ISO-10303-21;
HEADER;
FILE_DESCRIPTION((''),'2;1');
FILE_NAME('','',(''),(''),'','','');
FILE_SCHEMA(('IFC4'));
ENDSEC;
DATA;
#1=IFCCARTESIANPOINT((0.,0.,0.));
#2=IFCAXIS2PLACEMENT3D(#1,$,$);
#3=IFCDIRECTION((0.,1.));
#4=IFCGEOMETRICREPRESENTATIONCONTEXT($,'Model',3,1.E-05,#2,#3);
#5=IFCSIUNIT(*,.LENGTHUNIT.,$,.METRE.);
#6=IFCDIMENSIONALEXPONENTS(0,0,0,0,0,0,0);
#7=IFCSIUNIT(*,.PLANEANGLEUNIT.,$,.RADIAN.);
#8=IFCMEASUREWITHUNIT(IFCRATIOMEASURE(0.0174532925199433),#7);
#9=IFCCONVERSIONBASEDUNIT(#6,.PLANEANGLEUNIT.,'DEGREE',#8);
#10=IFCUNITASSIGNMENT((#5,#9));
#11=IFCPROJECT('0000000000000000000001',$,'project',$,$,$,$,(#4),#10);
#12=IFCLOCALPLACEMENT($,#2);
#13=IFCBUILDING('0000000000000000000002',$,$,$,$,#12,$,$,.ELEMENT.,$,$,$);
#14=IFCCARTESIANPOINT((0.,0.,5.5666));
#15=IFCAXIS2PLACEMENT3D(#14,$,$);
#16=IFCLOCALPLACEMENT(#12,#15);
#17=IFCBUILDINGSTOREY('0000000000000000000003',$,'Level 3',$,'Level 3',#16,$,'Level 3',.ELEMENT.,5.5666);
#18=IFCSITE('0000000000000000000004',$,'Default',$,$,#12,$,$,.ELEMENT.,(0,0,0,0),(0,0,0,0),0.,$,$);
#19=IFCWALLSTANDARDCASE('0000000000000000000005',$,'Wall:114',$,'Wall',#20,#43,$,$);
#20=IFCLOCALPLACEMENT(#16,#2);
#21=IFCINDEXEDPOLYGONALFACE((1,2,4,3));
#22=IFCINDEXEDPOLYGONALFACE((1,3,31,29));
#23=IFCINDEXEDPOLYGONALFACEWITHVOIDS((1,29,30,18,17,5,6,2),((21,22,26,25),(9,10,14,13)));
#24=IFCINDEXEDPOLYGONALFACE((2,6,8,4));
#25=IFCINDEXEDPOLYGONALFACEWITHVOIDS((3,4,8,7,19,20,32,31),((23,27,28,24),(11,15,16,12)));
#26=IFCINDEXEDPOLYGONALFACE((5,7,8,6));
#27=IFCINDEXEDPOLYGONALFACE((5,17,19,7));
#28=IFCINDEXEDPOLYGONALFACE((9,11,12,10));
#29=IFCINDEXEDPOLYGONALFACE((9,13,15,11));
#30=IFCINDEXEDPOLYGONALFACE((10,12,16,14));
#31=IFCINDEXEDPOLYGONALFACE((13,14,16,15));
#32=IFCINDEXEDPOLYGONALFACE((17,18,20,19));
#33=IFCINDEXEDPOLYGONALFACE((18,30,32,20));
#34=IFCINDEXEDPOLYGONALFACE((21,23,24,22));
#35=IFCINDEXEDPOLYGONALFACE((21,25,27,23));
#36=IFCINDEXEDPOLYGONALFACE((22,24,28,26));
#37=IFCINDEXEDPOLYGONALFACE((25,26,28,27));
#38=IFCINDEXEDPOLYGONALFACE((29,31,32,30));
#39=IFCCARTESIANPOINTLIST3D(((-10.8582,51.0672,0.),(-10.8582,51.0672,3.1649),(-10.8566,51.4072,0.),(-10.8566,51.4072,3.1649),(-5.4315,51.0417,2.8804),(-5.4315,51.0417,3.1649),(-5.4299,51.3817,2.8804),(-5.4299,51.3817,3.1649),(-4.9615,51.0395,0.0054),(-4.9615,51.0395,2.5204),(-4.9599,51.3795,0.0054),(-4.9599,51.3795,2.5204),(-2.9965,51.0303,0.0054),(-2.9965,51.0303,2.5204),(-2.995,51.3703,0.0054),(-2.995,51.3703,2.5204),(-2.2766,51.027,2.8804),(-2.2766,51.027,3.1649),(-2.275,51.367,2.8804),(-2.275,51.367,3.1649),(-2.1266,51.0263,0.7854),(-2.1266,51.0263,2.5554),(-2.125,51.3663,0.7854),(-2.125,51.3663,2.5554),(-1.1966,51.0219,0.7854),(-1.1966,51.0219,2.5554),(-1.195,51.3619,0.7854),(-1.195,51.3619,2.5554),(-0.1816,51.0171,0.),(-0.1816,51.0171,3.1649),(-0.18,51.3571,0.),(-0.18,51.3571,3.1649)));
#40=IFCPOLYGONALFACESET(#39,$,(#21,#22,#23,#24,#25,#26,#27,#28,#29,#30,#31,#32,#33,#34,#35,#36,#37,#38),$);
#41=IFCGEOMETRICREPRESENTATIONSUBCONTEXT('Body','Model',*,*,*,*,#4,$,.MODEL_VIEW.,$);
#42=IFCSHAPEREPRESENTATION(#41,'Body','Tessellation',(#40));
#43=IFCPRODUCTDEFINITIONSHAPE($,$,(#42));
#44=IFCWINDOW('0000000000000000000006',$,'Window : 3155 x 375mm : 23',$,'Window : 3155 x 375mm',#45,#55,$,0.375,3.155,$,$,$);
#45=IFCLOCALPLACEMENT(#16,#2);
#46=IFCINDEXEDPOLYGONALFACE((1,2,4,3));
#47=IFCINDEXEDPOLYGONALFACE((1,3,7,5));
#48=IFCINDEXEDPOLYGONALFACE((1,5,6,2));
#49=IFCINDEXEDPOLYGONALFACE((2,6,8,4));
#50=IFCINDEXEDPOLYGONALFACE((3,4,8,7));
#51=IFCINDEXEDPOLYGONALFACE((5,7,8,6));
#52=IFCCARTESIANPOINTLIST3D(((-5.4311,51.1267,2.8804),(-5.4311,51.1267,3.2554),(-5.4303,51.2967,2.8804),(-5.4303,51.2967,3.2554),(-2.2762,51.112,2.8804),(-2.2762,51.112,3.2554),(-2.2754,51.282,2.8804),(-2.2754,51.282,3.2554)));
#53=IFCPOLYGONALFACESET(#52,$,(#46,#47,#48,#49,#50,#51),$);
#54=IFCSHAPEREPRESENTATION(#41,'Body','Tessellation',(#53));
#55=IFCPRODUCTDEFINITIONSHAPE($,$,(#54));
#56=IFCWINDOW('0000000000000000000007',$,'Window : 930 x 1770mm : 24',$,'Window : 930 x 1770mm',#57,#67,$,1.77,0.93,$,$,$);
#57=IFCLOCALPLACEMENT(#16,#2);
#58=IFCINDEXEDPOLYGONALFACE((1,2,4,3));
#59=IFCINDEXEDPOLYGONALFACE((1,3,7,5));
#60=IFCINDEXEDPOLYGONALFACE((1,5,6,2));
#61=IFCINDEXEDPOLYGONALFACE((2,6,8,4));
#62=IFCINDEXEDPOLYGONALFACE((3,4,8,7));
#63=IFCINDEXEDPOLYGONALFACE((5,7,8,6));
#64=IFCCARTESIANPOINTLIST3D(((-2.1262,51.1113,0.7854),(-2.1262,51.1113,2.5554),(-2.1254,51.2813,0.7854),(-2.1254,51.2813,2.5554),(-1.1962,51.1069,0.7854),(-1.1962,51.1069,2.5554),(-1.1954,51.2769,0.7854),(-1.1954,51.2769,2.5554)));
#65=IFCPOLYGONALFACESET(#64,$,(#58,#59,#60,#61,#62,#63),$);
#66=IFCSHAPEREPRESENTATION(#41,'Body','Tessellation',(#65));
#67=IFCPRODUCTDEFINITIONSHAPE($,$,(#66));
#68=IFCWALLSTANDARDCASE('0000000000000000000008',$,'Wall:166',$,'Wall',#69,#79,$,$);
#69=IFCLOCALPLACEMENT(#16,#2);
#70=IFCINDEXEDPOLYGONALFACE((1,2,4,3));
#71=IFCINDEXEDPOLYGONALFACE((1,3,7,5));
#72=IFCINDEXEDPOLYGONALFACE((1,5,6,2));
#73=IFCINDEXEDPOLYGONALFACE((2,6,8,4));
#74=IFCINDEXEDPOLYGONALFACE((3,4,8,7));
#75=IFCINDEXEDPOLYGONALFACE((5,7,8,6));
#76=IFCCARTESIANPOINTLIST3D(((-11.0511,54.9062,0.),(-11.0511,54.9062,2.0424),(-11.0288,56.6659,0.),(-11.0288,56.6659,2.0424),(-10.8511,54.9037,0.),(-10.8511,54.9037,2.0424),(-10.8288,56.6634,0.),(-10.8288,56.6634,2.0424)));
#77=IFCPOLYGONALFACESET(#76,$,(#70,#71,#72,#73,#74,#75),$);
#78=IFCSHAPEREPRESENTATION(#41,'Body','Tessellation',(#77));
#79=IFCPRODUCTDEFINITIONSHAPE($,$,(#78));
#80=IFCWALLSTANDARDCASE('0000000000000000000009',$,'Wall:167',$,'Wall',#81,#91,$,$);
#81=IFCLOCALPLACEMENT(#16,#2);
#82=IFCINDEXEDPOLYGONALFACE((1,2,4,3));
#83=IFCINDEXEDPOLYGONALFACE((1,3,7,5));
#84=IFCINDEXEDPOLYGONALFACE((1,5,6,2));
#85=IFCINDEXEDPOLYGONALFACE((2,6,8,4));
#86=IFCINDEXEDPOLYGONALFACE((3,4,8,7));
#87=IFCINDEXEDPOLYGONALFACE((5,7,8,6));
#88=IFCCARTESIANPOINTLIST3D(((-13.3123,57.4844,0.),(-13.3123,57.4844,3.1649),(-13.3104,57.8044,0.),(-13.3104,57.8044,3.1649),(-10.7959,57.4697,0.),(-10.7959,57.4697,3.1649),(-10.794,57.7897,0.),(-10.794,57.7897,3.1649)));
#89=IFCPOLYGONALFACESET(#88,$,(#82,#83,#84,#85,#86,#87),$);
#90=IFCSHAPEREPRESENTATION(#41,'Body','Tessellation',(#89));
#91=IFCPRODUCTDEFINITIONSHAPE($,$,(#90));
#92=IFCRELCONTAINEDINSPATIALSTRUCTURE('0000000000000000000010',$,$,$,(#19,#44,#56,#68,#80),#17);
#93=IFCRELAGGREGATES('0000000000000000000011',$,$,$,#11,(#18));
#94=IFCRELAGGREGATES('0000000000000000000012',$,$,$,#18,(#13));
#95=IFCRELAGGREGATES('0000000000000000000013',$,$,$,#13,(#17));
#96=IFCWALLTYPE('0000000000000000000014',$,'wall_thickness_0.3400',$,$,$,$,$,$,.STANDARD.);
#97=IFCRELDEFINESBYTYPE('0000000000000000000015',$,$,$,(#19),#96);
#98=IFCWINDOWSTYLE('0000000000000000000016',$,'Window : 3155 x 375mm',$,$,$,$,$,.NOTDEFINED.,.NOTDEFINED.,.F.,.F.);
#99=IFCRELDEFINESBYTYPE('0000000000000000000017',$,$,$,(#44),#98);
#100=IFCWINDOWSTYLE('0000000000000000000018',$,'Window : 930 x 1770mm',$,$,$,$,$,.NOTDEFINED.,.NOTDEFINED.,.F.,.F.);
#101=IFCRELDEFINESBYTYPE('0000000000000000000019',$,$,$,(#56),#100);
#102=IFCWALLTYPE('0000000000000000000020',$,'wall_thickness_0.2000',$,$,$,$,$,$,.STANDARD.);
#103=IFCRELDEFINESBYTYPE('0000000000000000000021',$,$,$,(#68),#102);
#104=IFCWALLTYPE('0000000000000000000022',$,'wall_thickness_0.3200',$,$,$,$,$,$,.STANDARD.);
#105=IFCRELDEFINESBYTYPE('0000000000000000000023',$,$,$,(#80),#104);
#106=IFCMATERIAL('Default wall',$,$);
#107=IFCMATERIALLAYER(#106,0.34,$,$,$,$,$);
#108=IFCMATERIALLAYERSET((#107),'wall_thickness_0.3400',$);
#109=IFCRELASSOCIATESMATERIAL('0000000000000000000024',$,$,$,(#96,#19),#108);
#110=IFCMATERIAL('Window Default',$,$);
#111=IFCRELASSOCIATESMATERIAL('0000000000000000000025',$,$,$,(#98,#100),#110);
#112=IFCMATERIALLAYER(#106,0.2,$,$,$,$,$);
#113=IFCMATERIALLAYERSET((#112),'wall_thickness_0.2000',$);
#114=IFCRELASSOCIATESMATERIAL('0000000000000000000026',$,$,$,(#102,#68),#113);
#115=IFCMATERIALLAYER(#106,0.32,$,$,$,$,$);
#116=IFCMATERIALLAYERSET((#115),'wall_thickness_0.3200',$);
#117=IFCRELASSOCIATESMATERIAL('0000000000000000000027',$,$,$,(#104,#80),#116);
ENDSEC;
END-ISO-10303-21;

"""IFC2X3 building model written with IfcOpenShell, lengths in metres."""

from ifc_helpers import new_model, entity, si_unit, converted_unit, direction, frame, frame_2d, origin, origin_2d_with_axis, place, context, subcontext, project, spatial, polyline, rectangle, outline, extrude, source, transform, mapped, material, layer, layer_set, layer_usage, type_object, type_shapes, element, fill, save


model = new_model("IFC2X3")

# Units and contexts
model_context = context("Model", 3, precision=1e-05, world=origin(), true_north=direction((0.0, 1.0)))
body_context = subcontext(model_context, "Body", "Model", "MODEL_VIEW")
ifc_project = project(units=[si_unit("LENGTHUNIT", "METRE"), converted_unit("PLANEANGLEUNIT", "DEGREE", entity("IfcRatioMeasure", 0.0174532925199433), si_unit("PLANEANGLEUNIT", "RADIAN"), dimensions=[0, 0, 0, 0, 0, 0, 0])], contexts=[model_context])

# Site, building, storey
placement_1 = place(None, origin())
site = spatial("IfcSite", under=ifc_project, at=placement_1, Name="Default", CompositionType="ELEMENT", RefLatitude=(0, 0, 0, 0), RefLongitude=(0, 0, 0, 0), RefElevation=0.0)
building = spatial("IfcBuilding", under=site, at=placement_1, CompositionType="ELEMENT")
storey_placement = place(placement_1, frame((0.0, 0.0, 5.5666)))
storey = spatial("IfcBuildingStorey", under=building, at=storey_placement, Name="Level 3", ObjectType="Level 3", LongName="Level 3", CompositionType="ELEMENT", Elevation=5.5666)

# Shared definitions
ifc_material_1 = material(Name="Default wall")

# Shared definitions
ifc_material_2 = material(Name="Window Default")

# Wall, openings, windows
ifc_layer_1 = layer(ifc_material_1, 0.34)
ifc_layer_set_1 = layer_set([ifc_layer_1], Name="wall_thickness_0.3400")
ifc_layer_usage_1 = layer_usage(ifc_layer_set_1, "AXIS2", "POSITIVE", -0.17)
wall_type_1 = type_object("IfcWallType", Name="wall_thickness_0.3400", PredefinedType="STANDARD", material=ifc_layer_set_1)
wall_1_placement = place(storey_placement, frame((-10.8574, 51.2372, 0.0), z_axis=(0.0, 0.0, 1.0), x_axis=(0.999989, -0.004685, 0.0)))
wall_1 = element("IfcWallStandardCase", 1, at=wall_1_placement, inside=storey, type_object=wall_type_1, material=ifc_layer_usage_1, Name="Wall:114", ObjectType="Wall", context=body_context, shape_type="SweptSolid", body=[
    extrude(outline(polyline([(10.6768, -0.17), (10.6768, 0.17), (0.0, 0.17), (0.0, -0.17), (10.6768, -0.17)])), origin(), (0.0, 0.0, 1.0), 3.1649),
])
opening_1_placement = place(wall_1_placement, frame((5.8968, -0.17, 0.0054)))
element("IfcOpeningElement", 2, at=opening_1_placement, cuts=wall_1, ObjectType="Opening", context=body_context, shape_type="SweptSolid", body=[
    extrude(rectangle(XDim=1.965, YDim=2.515, at=frame_2d((1.2575, 0.9825), x_axis=(0.0, 1.0))), frame((0.0, 0.0, 0.0), z_axis=(0.0, 1.0, 0.0), x_axis=(0.0, 0.0, 1.0)), (0.0, 0.0, 1.0), 0.34),
])
opening_2_placement = place(wall_1_placement, frame((5.4268, -0.17, 2.8804)))
opening_2 = element("IfcOpeningElement", 3, at=opening_2_placement, cuts=wall_1, ObjectType="Opening", context=body_context, shape_type="SweptSolid", body=[
    extrude(rectangle(XDim=3.155, YDim=0.375, at=frame_2d((0.1875, 1.5775), x_axis=(0.0, 1.0))), frame((0.0, 0.0, 0.0), z_axis=(0.0, 1.0, 0.0), x_axis=(0.0, 0.0, 1.0)), (0.0, 0.0, 1.0), 0.34),
])
opening_3_placement = place(wall_1_placement, frame((8.7318, -0.17, 0.7854)))
opening_3 = element("IfcOpeningElement", 4, at=opening_3_placement, cuts=wall_1, ObjectType="Opening", context=body_context, shape_type="SweptSolid", body=[
    extrude(rectangle(XDim=0.93, YDim=1.77, at=frame_2d((0.885, 0.465), x_axis=(0.0, 1.0))), frame((0.0, 0.0, 0.0), z_axis=(0.0, 1.0, 0.0), x_axis=(0.0, 0.0, 1.0)), (0.0, 0.0, 1.0), 0.34),
])
window_style_1 = type_object("IfcWindowStyle", Name="Window : 3155 x 375mm", ConstructionType="NOTDEFINED", OperationType="NOTDEFINED", ParameterTakesPrecedence=False, Sizeable=False, material=ifc_material_2)
shared_shape_1 = source(origin(), body_context, "Body", "SweptSolid", [
    extrude(rectangle(XDim=0.17, YDim=3.155, at=origin_2d_with_axis()), frame((1.5775, 0.17, 0.0), z_axis=(0.0, 0.0, 1.0), x_axis=(0.0, 1.0, 0.0)), (0.0, 0.0, 1.0), 0.375),
])
type_shapes(window_style_1, [shared_shape_1])
window_1_placement = place(opening_2_placement, origin())
window_1 = element("IfcWindow", 5, at=window_1_placement, inside=storey, type_object=window_style_1, Name="Window : 3155 x 375mm : 23", ObjectType="Window : 3155 x 375mm", OverallHeight=0.375, OverallWidth=3.155, context=body_context, shape_type="MappedRepresentation", body=[
    mapped(shared_shape_1, transform((0.0, 0.0, 0.0), scale=1.0)),
])
fill(opening_2, window_1)
window_style_2 = type_object("IfcWindowStyle", Name="Window : 930 x 1770mm", ConstructionType="NOTDEFINED", OperationType="NOTDEFINED", ParameterTakesPrecedence=False, Sizeable=False, material=ifc_material_2)
shared_shape_2 = source(origin(), body_context, "Body", "SweptSolid", [
    extrude(rectangle(XDim=0.17, YDim=0.93, at=origin_2d_with_axis()), frame((0.465, 0.17, 0.0), z_axis=(0.0, 0.0, 1.0), x_axis=(0.0, 1.0, 0.0)), (0.0, 0.0, 1.0), 1.77),
])
type_shapes(window_style_2, [shared_shape_2])
window_2_placement = place(opening_3_placement, origin())
window_2 = element("IfcWindow", 6, at=window_2_placement, inside=storey, type_object=window_style_2, Name="Window : 930 x 1770mm : 24", ObjectType="Window : 930 x 1770mm", OverallHeight=1.77, OverallWidth=0.93, context=body_context, shape_type="MappedRepresentation", body=[
    mapped(shared_shape_2, transform((0.0, 0.0, 0.0), scale=1.0)),
])
fill(opening_3, window_2)

# Walls
ifc_layer_2 = layer(ifc_material_1, 0.2)
ifc_layer_set_2 = layer_set([ifc_layer_2], Name="wall_thickness_0.2000")
ifc_layer_usage_2 = layer_usage(ifc_layer_set_2, "AXIS2", "POSITIVE", -0.1)
wall_type_2 = type_object("IfcWallType", Name="wall_thickness_0.2000", PredefinedType="STANDARD", material=ifc_layer_set_2)
wall_2_placement = place(storey_placement, frame((-10.9288, 56.6647, 0.0), z_axis=(0.0, 0.0, 1.0), x_axis=(-0.012667, -0.99992, 0.0)))
element("IfcWallStandardCase", 7, at=wall_2_placement, inside=storey, type_object=wall_type_2, material=ifc_layer_usage_2, Name="Wall:166", ObjectType="Wall", context=body_context, shape_type="SweptSolid", body=[
    extrude(outline(polyline([(1.7598, -0.1), (1.7598, 0.1), (0.0, 0.1), (0.0, -0.1), (1.7598, -0.1)])), origin(), (0.0, 0.0, 1.0), 2.0424),
])
ifc_layer_3 = layer(ifc_material_1, 0.32)
ifc_layer_set_3 = layer_set([ifc_layer_3], Name="wall_thickness_0.3200")
ifc_layer_usage_3 = layer_usage(ifc_layer_set_3, "AXIS2", "POSITIVE", -0.16)
wall_type_3 = type_object("IfcWallType", Name="wall_thickness_0.3200", PredefinedType="STANDARD", material=ifc_layer_set_3)
wall_3_placement = place(storey_placement, frame((-10.7949, 57.6297, 0.0), z_axis=(0.0, 0.0, 1.0), x_axis=(-0.999983, 0.005871, 0.0)))
element("IfcWallStandardCase", 8, at=wall_3_placement, inside=storey, type_object=wall_type_3, material=ifc_layer_usage_3, Name="Wall:167", ObjectType="Wall", context=body_context, shape_type="SweptSolid", body=[
    extrude(outline(polyline([(2.5164, -0.16), (2.5164, 0.16), (0.0, 0.16), (0.0, -0.16), (2.5164, -0.16)])), origin(), (0.0, 0.0, 1.0), 3.1649),
])

save(model, "model.ifc")
